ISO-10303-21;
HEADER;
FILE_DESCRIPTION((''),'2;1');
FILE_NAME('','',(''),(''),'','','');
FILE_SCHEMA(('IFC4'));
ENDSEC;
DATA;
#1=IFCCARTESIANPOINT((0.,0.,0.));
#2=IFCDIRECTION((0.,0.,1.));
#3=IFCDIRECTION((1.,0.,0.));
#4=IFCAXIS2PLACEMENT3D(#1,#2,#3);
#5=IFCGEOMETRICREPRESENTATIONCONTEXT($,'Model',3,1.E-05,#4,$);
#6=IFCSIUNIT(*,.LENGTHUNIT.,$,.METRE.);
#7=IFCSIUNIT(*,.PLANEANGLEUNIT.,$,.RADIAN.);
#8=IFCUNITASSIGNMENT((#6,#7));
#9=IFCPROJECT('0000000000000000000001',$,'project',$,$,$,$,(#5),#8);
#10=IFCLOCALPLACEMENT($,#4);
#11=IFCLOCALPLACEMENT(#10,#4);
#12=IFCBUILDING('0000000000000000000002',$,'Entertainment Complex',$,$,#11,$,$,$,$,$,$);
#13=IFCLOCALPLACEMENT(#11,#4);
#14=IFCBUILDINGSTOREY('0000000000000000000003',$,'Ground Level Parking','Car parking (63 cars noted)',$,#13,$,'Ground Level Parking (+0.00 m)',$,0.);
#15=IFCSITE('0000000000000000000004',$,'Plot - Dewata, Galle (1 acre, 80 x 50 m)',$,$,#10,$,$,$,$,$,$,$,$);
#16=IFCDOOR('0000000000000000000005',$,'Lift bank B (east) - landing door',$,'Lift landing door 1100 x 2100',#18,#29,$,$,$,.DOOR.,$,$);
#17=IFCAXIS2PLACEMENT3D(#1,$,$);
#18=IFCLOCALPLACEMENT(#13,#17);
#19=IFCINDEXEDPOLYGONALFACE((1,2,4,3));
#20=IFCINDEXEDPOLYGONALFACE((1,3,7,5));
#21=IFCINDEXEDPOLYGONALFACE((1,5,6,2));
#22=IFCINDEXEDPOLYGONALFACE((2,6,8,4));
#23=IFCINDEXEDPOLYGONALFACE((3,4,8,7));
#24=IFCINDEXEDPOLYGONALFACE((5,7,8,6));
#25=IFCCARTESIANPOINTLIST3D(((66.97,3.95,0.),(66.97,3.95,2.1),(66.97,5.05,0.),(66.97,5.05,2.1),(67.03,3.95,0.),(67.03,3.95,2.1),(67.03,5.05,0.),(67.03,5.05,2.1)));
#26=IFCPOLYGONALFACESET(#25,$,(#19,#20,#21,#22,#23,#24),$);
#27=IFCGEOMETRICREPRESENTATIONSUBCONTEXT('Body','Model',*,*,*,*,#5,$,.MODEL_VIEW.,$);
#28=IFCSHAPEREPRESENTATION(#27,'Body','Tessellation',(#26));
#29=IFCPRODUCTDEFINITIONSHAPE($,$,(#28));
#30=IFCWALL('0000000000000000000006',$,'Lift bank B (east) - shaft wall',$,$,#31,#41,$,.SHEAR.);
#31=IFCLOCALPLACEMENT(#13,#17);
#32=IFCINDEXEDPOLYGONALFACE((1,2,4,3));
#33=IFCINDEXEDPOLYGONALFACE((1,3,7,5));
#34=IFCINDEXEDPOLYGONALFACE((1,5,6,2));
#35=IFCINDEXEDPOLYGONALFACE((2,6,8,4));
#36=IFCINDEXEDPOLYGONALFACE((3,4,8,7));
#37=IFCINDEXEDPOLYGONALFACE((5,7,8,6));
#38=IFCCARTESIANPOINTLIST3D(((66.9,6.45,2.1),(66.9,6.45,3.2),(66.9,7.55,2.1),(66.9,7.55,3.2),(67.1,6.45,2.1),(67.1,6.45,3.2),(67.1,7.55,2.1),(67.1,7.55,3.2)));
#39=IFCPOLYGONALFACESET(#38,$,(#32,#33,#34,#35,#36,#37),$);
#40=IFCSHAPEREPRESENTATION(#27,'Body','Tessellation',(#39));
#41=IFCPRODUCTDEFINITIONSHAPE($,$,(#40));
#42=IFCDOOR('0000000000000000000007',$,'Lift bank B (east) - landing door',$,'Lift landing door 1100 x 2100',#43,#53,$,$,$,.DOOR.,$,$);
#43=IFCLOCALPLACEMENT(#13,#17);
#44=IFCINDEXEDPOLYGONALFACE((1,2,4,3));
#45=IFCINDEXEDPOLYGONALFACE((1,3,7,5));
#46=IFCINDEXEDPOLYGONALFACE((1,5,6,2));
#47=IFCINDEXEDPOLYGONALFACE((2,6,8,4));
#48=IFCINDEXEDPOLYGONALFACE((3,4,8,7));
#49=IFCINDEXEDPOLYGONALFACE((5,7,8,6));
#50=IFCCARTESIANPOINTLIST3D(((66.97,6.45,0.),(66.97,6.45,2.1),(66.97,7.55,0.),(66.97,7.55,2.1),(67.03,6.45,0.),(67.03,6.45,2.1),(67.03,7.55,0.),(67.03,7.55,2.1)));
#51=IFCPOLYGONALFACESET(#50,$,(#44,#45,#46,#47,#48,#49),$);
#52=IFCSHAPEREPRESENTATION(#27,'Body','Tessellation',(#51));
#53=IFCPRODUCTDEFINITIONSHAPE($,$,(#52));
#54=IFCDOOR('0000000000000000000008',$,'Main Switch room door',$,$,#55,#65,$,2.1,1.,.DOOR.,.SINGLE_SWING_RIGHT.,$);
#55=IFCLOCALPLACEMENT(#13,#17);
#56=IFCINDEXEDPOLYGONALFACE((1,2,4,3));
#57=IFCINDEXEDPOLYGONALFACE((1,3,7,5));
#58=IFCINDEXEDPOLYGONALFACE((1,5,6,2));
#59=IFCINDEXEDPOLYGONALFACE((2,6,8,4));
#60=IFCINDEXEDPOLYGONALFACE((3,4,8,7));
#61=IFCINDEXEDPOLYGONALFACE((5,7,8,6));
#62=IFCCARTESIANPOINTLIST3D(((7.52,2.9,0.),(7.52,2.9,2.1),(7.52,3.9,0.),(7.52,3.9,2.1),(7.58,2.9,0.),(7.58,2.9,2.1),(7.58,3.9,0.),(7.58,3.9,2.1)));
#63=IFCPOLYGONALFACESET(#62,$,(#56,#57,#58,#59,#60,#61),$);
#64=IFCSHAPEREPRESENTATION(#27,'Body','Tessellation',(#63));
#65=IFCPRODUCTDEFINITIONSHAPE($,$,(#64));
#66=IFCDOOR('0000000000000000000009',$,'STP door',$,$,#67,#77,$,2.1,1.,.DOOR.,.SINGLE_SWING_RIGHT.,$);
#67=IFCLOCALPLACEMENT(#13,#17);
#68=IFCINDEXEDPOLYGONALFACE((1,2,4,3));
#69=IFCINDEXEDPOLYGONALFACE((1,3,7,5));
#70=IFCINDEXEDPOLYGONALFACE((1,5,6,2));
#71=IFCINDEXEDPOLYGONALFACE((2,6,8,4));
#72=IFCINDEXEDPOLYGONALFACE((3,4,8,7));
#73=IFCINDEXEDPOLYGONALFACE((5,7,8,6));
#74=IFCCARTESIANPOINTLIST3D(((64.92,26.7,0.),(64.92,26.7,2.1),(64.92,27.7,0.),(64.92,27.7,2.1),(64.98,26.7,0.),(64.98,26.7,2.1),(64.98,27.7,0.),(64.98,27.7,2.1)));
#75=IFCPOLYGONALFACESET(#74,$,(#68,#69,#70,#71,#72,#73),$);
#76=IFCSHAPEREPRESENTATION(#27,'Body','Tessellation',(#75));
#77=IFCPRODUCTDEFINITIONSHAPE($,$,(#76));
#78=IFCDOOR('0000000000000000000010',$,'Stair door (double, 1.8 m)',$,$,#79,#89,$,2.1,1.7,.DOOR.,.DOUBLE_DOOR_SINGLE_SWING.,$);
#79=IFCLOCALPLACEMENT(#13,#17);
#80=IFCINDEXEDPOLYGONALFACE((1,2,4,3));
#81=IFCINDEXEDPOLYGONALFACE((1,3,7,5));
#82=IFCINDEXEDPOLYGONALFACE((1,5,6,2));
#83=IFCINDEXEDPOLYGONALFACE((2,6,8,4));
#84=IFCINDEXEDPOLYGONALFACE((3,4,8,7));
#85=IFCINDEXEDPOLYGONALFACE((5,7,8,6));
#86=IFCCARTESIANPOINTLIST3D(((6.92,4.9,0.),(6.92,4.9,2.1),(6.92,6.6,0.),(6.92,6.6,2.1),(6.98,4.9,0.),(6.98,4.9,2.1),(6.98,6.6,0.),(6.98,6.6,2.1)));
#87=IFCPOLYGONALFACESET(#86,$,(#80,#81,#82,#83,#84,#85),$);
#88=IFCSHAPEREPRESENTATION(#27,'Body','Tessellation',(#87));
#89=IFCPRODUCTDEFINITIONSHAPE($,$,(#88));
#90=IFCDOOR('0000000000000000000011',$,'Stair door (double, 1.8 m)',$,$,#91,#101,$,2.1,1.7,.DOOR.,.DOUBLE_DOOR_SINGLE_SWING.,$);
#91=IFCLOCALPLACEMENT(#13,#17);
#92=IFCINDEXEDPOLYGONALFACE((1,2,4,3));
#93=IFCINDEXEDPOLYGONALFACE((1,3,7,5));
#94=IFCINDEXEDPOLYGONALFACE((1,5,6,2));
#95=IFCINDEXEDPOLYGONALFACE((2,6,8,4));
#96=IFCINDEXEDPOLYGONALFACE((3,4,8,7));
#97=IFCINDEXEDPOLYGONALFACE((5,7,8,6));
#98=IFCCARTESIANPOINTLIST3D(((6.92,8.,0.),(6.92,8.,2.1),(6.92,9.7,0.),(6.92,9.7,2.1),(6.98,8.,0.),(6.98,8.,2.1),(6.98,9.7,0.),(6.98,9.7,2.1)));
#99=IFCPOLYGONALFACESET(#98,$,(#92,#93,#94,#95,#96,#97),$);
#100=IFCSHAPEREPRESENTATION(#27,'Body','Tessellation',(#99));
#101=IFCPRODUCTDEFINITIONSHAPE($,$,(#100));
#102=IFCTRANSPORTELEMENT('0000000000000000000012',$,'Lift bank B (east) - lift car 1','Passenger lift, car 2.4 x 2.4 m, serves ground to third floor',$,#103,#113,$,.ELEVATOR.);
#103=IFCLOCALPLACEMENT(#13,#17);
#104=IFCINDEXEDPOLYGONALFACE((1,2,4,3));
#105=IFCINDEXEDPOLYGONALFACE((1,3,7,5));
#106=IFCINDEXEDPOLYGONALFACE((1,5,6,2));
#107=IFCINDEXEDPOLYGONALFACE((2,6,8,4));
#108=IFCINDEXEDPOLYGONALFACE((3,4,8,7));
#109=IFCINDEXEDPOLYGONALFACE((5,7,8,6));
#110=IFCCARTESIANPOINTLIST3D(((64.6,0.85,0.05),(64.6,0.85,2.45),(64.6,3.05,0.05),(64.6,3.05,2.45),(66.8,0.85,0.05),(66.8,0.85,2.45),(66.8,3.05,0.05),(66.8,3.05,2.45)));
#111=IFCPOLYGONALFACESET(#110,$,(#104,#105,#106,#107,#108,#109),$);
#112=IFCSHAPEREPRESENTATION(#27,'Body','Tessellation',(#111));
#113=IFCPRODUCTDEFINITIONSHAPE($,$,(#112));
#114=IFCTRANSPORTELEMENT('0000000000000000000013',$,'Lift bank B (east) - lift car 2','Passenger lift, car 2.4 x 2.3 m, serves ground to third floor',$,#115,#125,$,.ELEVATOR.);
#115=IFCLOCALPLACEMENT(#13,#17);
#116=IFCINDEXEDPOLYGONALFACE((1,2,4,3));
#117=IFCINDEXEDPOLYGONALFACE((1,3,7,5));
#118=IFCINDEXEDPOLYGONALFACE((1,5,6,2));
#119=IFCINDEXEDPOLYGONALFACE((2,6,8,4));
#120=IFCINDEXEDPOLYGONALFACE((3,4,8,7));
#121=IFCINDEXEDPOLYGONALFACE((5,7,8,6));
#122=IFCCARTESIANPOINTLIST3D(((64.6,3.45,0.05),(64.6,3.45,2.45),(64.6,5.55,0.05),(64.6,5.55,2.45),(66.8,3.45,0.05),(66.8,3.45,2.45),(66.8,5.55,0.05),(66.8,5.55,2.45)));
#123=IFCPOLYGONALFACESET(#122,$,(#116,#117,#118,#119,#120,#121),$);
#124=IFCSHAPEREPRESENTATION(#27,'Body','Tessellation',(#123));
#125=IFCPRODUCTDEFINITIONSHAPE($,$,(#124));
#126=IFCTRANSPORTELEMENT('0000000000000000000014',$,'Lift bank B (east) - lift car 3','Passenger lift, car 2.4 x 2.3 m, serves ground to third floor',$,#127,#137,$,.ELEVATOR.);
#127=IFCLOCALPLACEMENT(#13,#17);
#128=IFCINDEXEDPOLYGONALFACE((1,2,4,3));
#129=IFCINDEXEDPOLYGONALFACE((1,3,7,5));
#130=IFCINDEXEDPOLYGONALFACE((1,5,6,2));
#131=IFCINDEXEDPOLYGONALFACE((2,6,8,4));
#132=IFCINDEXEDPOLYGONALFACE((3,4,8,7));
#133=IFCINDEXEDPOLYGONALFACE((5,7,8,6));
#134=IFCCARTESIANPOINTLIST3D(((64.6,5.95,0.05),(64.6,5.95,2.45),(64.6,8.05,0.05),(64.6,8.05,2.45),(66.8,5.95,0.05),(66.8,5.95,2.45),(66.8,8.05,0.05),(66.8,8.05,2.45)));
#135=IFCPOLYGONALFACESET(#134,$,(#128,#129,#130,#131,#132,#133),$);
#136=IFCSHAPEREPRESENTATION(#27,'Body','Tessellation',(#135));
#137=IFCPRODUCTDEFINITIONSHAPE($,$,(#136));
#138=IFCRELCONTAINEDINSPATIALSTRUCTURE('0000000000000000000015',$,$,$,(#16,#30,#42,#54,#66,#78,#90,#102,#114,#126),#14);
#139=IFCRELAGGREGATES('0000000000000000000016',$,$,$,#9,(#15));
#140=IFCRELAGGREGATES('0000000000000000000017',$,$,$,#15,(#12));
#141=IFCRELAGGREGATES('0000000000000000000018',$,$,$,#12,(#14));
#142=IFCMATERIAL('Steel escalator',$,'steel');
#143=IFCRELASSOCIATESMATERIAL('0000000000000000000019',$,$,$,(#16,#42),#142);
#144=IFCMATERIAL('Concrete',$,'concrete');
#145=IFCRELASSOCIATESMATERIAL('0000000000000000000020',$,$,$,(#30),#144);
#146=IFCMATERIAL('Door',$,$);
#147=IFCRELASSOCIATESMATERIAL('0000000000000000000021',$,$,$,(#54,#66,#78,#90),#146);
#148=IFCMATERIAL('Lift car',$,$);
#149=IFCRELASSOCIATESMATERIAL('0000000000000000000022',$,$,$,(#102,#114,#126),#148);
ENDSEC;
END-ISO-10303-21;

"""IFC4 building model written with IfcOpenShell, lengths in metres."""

from ifc_helpers import new_model, si_unit, frame, origin_with_axes, place, context, subcontext, project, spatial, polyline, outline, extrude, material, element, save


model = new_model("IFC4")

# Units and contexts
model_context = context("Model", 3, precision=1e-05, world=origin_with_axes())
body_context = subcontext(model_context, "Body", "Model", "MODEL_VIEW")
ifc_project = project(units=[si_unit("LENGTHUNIT", "METRE"), si_unit("PLANEANGLEUNIT", "RADIAN")], contexts=[model_context])

# Site, building, storey
site_placement = place(None, origin_with_axes())
site = spatial("IfcSite", under=ifc_project, at=site_placement, Name="Plot - Dewata, Galle (1 acre, 80 x 50 m)")
building_placement = place(site_placement, origin_with_axes())
building = spatial("IfcBuilding", under=site, at=building_placement, Name="Entertainment Complex")
storey_placement = place(building_placement, origin_with_axes())
storey = spatial("IfcBuildingStorey", under=building, at=storey_placement, Name="Ground Level Parking", Description="Car parking (63 cars noted)", LongName="Ground Level Parking (+0.00 m)", Elevation=0.0)

# Shared definitions
ifc_material_1 = material(Name="Concrete", Category="concrete")

# Shared definitions
ifc_material_2 = material(Name="Steel escalator", Category="steel")

# Door
door_1_placement = place(storey_placement, origin_with_axes())
element("IfcDoor", 1, at=door_1_placement, inside=storey, material=ifc_material_2, Name="Lift bank B (east) - landing door", ObjectType="Lift landing door 1100 x 2100", PredefinedType="DOOR", context=body_context, shape_type="SweptSolid", body=[
    extrude(outline(polyline([(66.97, 3.95), (67.03, 3.95), (67.03, 5.05), (66.97, 5.05), (66.97, 3.95)])), origin_with_axes(), (0.0, 0.0, 1.0), 2.1),
])

# Wall
wall_1_placement = place(storey_placement, origin_with_axes())
element("IfcWall", 2, at=wall_1_placement, inside=storey, material=ifc_material_1, Name="Lift bank B (east) - shaft wall", PredefinedType="SHEAR", context=body_context, shape_type="SweptSolid", body=[
    extrude(outline(polyline([(66.9, 6.45), (67.1, 6.45), (67.1, 7.55), (66.9, 7.55), (66.9, 6.45)])), frame((0.0, 0.0, 2.1), z_axis=(0.0, 0.0, 1.0), x_axis=(1.0, 0.0, 0.0)), (0.0, 0.0, 1.0), 1.1),
])

# Doors
door_2_placement = place(storey_placement, origin_with_axes())
element("IfcDoor", 3, at=door_2_placement, inside=storey, material=ifc_material_2, Name="Lift bank B (east) - landing door", ObjectType="Lift landing door 1100 x 2100", PredefinedType="DOOR", context=body_context, shape_type="SweptSolid", body=[
    extrude(outline(polyline([(66.97, 6.45), (67.03, 6.45), (67.03, 7.55), (66.97, 7.55), (66.97, 6.45)])), origin_with_axes(), (0.0, 0.0, 1.0), 2.1),
])
ifc_material_3 = material(Name="Door")
door_3_placement = place(storey_placement, origin_with_axes())
element("IfcDoor", 4, at=door_3_placement, inside=storey, material=ifc_material_3, Name="Main Switch room door", OperationType="SINGLE_SWING_RIGHT", OverallHeight=2.1, OverallWidth=1.0, PredefinedType="DOOR", context=body_context, shape_type="SweptSolid", body=[
    extrude(outline(polyline([(7.52, 2.9), (7.58, 2.9), (7.58, 3.9), (7.52, 3.9), (7.52, 2.9)])), origin_with_axes(), (0.0, 0.0, 1.0), 2.1),
])
door_4_placement = place(storey_placement, origin_with_axes())
element("IfcDoor", 5, at=door_4_placement, inside=storey, material=ifc_material_3, Name="STP door", OperationType="SINGLE_SWING_RIGHT", OverallHeight=2.1, OverallWidth=1.0, PredefinedType="DOOR", context=body_context, shape_type="SweptSolid", body=[
    extrude(outline(polyline([(64.92, 26.7), (64.98, 26.7), (64.98, 27.7), (64.92, 27.7), (64.92, 26.7)])), origin_with_axes(), (0.0, 0.0, 1.0), 2.1),
])
door_5_placement = place(storey_placement, origin_with_axes())
element("IfcDoor", 6, at=door_5_placement, inside=storey, material=ifc_material_3, Name="Stair door (double, 1.8 m)", OperationType="DOUBLE_DOOR_SINGLE_SWING", OverallHeight=2.1, OverallWidth=1.7, PredefinedType="DOOR", context=body_context, shape_type="SweptSolid", body=[
    extrude(outline(polyline([(6.92, 4.9), (6.98, 4.9), (6.98, 6.6), (6.92, 6.6), (6.92, 4.9)])), origin_with_axes(), (0.0, 0.0, 1.0), 2.1),
])
door_6_placement = place(storey_placement, origin_with_axes())
element("IfcDoor", 7, at=door_6_placement, inside=storey, material=ifc_material_3, Name="Stair door (double, 1.8 m)", OperationType="DOUBLE_DOOR_SINGLE_SWING", OverallHeight=2.1, OverallWidth=1.7, PredefinedType="DOOR", context=body_context, shape_type="SweptSolid", body=[
    extrude(outline(polyline([(6.92, 8.0), (6.98, 8.0), (6.98, 9.7), (6.92, 9.7), (6.92, 8.0)])), origin_with_axes(), (0.0, 0.0, 1.0), 2.1),
])

# Transport elements
ifc_material_4 = material(Name="Lift car")
transport_element_1_placement = place(storey_placement, origin_with_axes())
element("IfcTransportElement", 8, at=transport_element_1_placement, inside=storey, material=ifc_material_4, Name="Lift bank B (east) - lift car 1", Description="Passenger lift, car 2.4 x 2.4 m, serves ground to third floor", PredefinedType="ELEVATOR", context=body_context, shape_type="SweptSolid", body=[
    extrude(outline(polyline([(64.6, 0.85), (66.8, 0.85), (66.8, 3.05), (64.6, 3.05), (64.6, 0.85)])), frame((0.0, 0.0, 0.05), z_axis=(0.0, 0.0, 1.0), x_axis=(1.0, 0.0, 0.0)), (0.0, 0.0, 1.0), 2.4),
])
transport_element_2_placement = place(storey_placement, origin_with_axes())
element("IfcTransportElement", 9, at=transport_element_2_placement, inside=storey, material=ifc_material_4, Name="Lift bank B (east) - lift car 2", Description="Passenger lift, car 2.4 x 2.3 m, serves ground to third floor", PredefinedType="ELEVATOR", context=body_context, shape_type="SweptSolid", body=[
    extrude(outline(polyline([(64.6, 3.45), (66.8, 3.45), (66.8, 5.55), (64.6, 5.55), (64.6, 3.45)])), frame((0.0, 0.0, 0.05), z_axis=(0.0, 0.0, 1.0), x_axis=(1.0, 0.0, 0.0)), (0.0, 0.0, 1.0), 2.4),
])
transport_element_3_placement = place(storey_placement, origin_with_axes())
element("IfcTransportElement", 10, at=transport_element_3_placement, inside=storey, material=ifc_material_4, Name="Lift bank B (east) - lift car 3", Description="Passenger lift, car 2.4 x 2.3 m, serves ground to third floor", PredefinedType="ELEVATOR", context=body_context, shape_type="SweptSolid", body=[
    extrude(outline(polyline([(64.6, 5.95), (66.8, 5.95), (66.8, 8.05), (64.6, 8.05), (64.6, 5.95)])), frame((0.0, 0.0, 0.05), z_axis=(0.0, 0.0, 1.0), x_axis=(1.0, 0.0, 0.0)), (0.0, 0.0, 1.0), 2.4),
])

save(model, "model.ifc")
